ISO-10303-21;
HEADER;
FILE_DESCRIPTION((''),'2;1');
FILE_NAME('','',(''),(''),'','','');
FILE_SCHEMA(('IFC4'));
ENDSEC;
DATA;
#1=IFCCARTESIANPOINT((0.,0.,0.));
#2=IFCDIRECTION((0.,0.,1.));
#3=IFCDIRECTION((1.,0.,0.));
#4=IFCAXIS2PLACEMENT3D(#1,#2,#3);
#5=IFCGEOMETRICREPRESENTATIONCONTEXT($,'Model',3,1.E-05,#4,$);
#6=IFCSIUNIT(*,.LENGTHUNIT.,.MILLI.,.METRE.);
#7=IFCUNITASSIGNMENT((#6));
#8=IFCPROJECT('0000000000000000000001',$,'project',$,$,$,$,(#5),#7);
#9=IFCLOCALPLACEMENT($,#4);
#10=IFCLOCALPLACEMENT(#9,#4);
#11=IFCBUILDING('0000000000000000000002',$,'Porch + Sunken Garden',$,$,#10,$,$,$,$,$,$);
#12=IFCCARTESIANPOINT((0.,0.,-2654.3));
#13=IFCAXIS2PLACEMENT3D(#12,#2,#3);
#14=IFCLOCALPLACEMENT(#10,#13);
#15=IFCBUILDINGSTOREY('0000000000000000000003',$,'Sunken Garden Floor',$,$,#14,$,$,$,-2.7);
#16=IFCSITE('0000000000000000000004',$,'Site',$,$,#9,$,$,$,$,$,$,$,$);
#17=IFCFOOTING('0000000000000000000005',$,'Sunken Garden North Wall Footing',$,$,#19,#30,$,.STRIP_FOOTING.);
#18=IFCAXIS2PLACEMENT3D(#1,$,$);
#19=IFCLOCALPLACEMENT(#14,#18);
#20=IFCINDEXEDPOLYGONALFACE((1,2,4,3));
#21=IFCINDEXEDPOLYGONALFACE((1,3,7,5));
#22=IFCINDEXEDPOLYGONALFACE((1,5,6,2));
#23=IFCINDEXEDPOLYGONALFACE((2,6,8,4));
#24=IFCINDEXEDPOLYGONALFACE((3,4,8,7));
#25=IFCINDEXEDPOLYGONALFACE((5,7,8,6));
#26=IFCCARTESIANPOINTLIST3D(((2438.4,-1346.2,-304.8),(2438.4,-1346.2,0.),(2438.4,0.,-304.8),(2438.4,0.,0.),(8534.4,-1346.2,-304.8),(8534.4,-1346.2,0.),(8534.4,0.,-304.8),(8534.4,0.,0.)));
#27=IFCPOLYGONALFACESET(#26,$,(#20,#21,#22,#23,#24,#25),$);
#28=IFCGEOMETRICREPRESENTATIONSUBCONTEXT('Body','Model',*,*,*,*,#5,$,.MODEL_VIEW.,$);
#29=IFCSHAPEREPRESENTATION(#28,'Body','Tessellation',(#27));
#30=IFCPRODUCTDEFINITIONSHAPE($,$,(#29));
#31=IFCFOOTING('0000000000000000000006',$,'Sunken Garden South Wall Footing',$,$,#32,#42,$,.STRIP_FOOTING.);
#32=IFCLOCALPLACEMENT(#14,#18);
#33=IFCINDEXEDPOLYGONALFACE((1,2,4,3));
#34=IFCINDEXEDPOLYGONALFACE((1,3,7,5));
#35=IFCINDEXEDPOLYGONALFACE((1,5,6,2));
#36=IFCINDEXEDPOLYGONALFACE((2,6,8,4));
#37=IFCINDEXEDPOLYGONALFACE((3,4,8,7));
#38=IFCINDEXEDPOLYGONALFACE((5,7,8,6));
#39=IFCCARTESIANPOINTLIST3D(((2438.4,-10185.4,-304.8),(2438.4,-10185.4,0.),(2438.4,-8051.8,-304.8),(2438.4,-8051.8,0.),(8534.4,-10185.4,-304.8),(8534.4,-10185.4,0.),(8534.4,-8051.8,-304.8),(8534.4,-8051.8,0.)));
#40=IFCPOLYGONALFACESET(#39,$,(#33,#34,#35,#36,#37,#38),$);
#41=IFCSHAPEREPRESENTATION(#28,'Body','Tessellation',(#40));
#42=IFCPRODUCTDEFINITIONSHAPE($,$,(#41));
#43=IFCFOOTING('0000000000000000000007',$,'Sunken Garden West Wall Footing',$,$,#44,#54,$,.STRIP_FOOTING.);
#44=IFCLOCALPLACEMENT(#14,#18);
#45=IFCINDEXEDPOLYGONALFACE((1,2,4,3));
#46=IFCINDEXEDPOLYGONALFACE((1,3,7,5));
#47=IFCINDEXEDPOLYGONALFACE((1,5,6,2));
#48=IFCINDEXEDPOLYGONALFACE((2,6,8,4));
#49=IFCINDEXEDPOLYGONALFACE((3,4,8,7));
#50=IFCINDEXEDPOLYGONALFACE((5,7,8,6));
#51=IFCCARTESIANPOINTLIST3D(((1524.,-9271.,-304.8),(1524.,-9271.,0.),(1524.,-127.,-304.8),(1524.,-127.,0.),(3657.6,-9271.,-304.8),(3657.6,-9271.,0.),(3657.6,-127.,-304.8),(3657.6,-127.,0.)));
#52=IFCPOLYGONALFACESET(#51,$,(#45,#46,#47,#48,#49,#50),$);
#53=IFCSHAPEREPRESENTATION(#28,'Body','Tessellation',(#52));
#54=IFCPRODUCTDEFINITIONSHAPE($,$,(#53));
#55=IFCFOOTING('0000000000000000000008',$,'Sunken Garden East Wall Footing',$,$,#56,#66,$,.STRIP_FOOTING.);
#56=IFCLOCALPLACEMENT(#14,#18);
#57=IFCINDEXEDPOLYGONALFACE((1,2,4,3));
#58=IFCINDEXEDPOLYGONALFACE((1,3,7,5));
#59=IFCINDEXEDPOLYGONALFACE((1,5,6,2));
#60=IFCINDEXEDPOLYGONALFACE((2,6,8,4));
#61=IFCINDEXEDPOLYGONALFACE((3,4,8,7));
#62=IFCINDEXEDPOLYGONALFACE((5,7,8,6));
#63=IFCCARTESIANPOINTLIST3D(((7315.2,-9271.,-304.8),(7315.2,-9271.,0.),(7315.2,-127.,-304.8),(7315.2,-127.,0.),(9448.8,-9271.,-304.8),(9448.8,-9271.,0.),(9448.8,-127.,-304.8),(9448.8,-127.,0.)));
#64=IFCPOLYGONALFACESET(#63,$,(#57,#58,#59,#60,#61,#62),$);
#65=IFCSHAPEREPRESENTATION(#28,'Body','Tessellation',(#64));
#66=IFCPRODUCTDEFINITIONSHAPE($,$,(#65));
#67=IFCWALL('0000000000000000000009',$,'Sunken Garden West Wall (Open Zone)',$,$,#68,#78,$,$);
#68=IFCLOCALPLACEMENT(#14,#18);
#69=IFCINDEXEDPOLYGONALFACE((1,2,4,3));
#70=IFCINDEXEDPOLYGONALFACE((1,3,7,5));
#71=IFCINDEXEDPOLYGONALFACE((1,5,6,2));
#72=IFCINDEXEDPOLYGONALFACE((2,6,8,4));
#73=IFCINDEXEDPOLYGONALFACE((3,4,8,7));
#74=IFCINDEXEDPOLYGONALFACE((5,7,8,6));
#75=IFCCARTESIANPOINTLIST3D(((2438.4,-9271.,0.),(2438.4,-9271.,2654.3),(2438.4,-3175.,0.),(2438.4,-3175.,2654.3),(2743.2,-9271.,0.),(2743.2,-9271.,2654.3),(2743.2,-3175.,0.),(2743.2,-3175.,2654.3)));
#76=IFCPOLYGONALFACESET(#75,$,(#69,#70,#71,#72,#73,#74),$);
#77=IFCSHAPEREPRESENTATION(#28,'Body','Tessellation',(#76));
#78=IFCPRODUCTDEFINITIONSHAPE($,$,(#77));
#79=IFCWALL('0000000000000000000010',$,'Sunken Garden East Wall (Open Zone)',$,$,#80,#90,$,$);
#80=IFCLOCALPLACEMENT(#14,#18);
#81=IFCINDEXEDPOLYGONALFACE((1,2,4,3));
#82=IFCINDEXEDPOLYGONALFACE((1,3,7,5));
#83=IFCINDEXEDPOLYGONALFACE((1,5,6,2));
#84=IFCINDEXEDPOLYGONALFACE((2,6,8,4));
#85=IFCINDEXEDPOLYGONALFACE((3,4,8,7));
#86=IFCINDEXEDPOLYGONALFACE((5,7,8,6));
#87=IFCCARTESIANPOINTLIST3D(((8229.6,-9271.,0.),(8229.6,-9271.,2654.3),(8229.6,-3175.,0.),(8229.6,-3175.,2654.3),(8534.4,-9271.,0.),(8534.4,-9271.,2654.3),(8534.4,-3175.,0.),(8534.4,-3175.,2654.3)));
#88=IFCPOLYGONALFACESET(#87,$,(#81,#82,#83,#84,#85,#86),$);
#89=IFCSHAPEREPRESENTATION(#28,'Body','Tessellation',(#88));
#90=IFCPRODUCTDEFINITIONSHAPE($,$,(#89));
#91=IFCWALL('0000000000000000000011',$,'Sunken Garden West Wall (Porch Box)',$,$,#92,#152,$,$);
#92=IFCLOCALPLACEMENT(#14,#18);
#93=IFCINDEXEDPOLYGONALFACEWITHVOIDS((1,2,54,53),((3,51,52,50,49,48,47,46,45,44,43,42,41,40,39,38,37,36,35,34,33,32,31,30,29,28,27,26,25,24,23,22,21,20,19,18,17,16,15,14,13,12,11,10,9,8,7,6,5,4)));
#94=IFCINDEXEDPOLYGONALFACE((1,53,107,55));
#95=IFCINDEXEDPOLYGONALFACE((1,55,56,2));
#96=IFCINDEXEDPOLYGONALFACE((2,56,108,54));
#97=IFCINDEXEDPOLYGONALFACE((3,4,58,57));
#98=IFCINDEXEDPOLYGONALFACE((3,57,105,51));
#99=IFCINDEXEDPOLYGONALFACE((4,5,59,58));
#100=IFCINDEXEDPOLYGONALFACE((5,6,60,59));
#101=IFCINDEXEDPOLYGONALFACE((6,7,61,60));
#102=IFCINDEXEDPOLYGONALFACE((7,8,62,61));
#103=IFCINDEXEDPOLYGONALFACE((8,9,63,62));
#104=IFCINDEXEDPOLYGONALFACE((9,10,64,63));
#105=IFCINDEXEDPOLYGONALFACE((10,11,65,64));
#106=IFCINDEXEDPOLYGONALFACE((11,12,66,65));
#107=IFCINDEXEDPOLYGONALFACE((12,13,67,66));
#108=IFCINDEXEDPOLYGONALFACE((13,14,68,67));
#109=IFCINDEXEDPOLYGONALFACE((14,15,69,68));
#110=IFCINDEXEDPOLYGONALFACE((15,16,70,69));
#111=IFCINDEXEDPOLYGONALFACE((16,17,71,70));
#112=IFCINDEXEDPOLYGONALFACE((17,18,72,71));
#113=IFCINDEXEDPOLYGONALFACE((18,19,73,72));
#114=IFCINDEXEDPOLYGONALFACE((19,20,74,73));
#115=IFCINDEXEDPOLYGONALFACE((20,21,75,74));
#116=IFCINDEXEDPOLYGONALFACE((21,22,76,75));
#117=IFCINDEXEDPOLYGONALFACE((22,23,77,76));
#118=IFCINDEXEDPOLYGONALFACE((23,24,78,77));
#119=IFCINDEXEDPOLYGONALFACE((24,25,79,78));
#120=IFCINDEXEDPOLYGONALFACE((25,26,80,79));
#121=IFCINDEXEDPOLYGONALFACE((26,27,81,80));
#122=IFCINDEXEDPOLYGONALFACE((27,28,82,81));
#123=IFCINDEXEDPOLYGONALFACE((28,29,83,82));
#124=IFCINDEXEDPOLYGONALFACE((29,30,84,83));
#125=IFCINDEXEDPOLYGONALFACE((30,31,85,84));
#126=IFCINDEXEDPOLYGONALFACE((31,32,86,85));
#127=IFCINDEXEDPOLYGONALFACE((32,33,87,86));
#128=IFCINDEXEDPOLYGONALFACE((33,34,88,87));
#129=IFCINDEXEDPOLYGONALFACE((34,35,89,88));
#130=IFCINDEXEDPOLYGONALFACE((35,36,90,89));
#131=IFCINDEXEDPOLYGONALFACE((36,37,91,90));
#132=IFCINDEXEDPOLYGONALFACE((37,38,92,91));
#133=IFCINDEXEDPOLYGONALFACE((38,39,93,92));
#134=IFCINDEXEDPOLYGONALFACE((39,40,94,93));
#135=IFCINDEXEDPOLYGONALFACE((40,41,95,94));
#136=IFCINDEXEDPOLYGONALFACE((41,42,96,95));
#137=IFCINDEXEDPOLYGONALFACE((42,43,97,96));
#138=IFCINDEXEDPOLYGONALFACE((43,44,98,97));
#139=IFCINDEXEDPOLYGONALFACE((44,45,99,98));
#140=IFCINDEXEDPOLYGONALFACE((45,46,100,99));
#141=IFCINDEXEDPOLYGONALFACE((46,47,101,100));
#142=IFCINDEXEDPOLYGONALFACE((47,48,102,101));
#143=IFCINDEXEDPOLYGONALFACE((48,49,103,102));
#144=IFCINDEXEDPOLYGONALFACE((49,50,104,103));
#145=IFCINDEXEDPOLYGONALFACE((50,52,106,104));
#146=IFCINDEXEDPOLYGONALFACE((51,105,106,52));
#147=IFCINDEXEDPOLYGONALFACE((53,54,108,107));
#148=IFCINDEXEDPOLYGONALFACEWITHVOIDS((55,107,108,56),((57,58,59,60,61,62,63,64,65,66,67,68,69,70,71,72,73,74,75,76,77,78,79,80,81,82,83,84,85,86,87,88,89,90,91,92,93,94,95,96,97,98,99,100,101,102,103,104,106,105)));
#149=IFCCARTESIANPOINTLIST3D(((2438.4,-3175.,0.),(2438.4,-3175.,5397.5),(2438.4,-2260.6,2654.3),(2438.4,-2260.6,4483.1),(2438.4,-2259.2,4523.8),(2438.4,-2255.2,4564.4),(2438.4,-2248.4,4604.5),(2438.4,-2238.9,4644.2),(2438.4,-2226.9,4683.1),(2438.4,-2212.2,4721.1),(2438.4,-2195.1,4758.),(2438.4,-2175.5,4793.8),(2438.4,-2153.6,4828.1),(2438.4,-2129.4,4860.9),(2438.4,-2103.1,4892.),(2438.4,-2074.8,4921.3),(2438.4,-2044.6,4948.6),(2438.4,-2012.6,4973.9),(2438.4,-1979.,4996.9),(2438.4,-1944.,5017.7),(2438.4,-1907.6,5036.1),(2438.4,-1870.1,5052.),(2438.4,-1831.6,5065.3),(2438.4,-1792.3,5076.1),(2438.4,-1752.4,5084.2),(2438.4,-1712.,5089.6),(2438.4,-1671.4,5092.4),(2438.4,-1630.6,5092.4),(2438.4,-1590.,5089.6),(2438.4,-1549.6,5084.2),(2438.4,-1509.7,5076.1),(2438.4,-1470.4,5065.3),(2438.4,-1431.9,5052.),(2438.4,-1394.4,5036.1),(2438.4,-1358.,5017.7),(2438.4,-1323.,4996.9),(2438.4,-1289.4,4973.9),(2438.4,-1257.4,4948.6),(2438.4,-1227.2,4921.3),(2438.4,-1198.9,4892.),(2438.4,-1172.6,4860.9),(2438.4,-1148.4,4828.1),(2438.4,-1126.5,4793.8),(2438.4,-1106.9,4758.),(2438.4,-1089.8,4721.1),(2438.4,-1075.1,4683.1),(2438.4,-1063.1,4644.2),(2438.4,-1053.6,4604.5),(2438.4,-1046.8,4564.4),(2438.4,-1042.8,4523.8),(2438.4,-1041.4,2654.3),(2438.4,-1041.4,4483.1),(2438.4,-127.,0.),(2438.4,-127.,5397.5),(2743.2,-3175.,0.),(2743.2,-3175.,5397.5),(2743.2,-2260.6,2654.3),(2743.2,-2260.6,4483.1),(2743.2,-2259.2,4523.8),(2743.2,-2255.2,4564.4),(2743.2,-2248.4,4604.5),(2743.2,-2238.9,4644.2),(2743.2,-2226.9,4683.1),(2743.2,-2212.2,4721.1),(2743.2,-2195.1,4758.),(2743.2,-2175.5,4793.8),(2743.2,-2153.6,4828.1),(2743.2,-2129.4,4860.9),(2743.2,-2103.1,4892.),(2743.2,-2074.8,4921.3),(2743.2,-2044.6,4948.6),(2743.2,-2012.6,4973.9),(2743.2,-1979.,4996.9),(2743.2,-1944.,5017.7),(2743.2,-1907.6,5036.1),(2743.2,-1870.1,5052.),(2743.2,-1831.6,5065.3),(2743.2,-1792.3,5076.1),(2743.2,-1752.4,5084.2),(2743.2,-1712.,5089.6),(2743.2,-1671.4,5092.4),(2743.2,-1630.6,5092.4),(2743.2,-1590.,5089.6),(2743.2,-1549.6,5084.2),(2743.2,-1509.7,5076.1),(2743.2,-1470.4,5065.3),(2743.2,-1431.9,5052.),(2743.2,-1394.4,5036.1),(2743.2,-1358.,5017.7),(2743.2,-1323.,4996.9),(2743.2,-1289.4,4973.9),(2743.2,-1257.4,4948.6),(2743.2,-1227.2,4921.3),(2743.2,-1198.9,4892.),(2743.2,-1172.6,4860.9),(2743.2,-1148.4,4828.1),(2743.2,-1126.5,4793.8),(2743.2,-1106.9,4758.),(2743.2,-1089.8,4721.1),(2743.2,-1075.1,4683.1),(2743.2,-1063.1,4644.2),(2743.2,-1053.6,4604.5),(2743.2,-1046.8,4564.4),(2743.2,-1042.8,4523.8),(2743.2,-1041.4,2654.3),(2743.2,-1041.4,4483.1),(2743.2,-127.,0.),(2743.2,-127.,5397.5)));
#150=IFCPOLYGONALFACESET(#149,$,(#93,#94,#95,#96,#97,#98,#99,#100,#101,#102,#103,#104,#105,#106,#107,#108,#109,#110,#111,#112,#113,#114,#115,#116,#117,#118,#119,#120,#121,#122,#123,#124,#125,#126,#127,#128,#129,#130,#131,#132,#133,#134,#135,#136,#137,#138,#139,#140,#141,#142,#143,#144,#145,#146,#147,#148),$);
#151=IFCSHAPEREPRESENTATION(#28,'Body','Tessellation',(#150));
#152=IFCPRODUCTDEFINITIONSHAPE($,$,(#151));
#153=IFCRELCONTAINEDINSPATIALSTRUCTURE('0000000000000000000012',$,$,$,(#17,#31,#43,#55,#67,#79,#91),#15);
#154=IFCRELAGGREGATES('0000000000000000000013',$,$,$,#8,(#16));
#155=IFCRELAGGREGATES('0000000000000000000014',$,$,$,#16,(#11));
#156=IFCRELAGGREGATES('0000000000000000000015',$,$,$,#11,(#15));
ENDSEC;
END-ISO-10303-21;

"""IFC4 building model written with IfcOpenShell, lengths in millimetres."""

from ifc_helpers import new_model, si_unit, frame, origin_with_axes, place, context, subcontext, project, spatial, indexed_curve, outline, extrude, element, save


model = new_model("IFC4")

# Units and contexts
model_context = context("Model", 3, precision=1e-05, world=origin_with_axes())
body_context = subcontext(model_context, "Body", "Model", "MODEL_VIEW")
ifc_project = project(units=[si_unit("LENGTHUNIT", "METRE", prefix="MILLI")], contexts=[model_context])

# Site, building, storey
site_placement = place(None, origin_with_axes())
site = spatial("IfcSite", under=ifc_project, at=site_placement, Name="Site")
building_placement = place(site_placement, origin_with_axes())
building = spatial("IfcBuilding", under=site, at=building_placement, Name="Porch + Sunken Garden")
storey_placement = place(building_placement, frame((0.0, 0.0, -2654.3), z_axis=(0.0, 0.0, 1.0), x_axis=(1.0, 0.0, 0.0)))
storey = spatial("IfcBuildingStorey", under=building, at=storey_placement, Name="Sunken Garden Floor", Elevation=-2.7)

# Footings
footing_1_placement = place(storey_placement, frame((2438.4, -1346.2, -304.8), z_axis=(0.0, 0.0, 1.0), x_axis=(1.0, 0.0, 0.0)))
element("IfcFooting", 1, at=footing_1_placement, inside=storey, Name="Sunken Garden North Wall Footing", PredefinedType="STRIP_FOOTING", context=body_context, shape_type="SweptSolid", body=[
    extrude(outline(indexed_curve([(0.0, 0.0), (6096.0, 0.0), (6096.0, 1346.2), (0.0, 1346.2), (0.0, 0.0)])), origin_with_axes(), (0.0, 0.0, 1.0), 304.8),
])
footing_2_placement = place(storey_placement, frame((2438.4, -10185.4, -304.8), z_axis=(0.0, 0.0, 1.0), x_axis=(1.0, 0.0, 0.0)))
element("IfcFooting", 2, at=footing_2_placement, inside=storey, Name="Sunken Garden South Wall Footing", PredefinedType="STRIP_FOOTING", context=body_context, shape_type="SweptSolid", body=[
    extrude(outline(indexed_curve([(0.0, 0.0), (6096.0, 0.0), (6096.0, 2133.6), (0.0, 2133.6), (0.0, 0.0)])), origin_with_axes(), (0.0, 0.0, 1.0), 304.8),
])
for number, where, z_axis, x_axis, name in (
    (3, (1524.0, -9271.0, -304.8), (0.0, 0.0, 1.0), (1.0, 0.0, 0.0), "Sunken Garden West Wall Footing"),
    (4, (7315.2, -9271.0, -304.8), (0.0, 0.0, 1.0), (1.0, 0.0, 0.0), "Sunken Garden East Wall Footing"),
):
    element("IfcFooting", number, at=place(storey_placement, frame(where, z_axis=z_axis, x_axis=x_axis)), inside=storey, Name=name, PredefinedType="STRIP_FOOTING", context=body_context, shape_type="SweptSolid", body=[
        extrude(outline(indexed_curve([(0.0, 0.0), (2133.6, 0.0), (2133.6, 9144.0), (0.0, 9144.0), (0.0, 0.0)])), origin_with_axes(), (0.0, 0.0, 1.0), 304.8),
    ])

# Walls
for number, where, z_axis, x_axis, name in (
    (5, (2438.4, -9271.0, 0.0), (0.0, 0.0, 1.0), (1.0, 0.0, 0.0), "Sunken Garden West Wall (Open Zone)"),
    (6, (8229.6, -9271.0, 0.0), (0.0, 0.0, 1.0), (1.0, 0.0, 0.0), "Sunken Garden East Wall (Open Zone)"),
):
    element("IfcWall", number, at=place(storey_placement, frame(where, z_axis=z_axis, x_axis=x_axis)), inside=storey, Name=name, context=body_context, shape_type="SweptSolid", body=[
        extrude(outline(indexed_curve([(0.0, 0.0), (304.8, 0.0), (304.8, 6096.0), (0.0, 6096.0), (0.0, 0.0)])), origin_with_axes(), (0.0, 0.0, 1.0), 2654.3),
    ])
wall_1_placement = place(storey_placement, frame((2438.4, -127.0, 0.0), z_axis=(1.0, 0.0, 0.0), x_axis=(0.0, -1.0, 0.0)))
element("IfcWall", 7, at=wall_1_placement, inside=storey, Name="Sunken Garden West Wall (Porch Box)", context=body_context, shape_type="SweptSolid", body=[
    extrude(outline(indexed_curve([(0.0, 0.0), (3048.0, 0.0), (3048.0, -5397.5), (0.0, -5397.5), (0.0, 0.0)]), holes=[indexed_curve([(914.4, -2654.3), (914.4, -4483.1), (914.4, -4483.1), (915.8, -4523.8), (919.8, -4564.4), (926.6, -4604.5), (936.1, -4644.2), (948.1, -4683.1), (962.8, -4721.1), (979.9, -4758.0), (999.5, -4793.8), (1021.4, -4828.1), (1045.6, -4860.9), (1071.9, -4892.0), (1100.2, -4921.3), (1130.4, -4948.6), (1162.4, -4973.9), (1196.0, -4996.9), (1231.0, -5017.7), (1267.4, -5036.1), (1304.9, -5052.0), (1343.4, -5065.3), (1382.7, -5076.1), (1422.6, -5084.2), (1463.0, -5089.6), (1503.6, -5092.4), (1544.4, -5092.4), (1585.0, -5089.6), (1625.4, -5084.2), (1665.3, -5076.1), (1704.6, -5065.3), (1743.1, -5052.0), (1780.6, -5036.1), (1817.0, -5017.7), (1852.0, -4996.9), (1885.6, -4973.9), (1917.6, -4948.6), (1947.8, -4921.3), (1976.1, -4892.0), (2002.4, -4860.9), (2026.6, -4828.1), (2048.5, -4793.8), (2068.1, -4758.0), (2085.2, -4721.1), (2099.9, -4683.1), (2111.9, -4644.2), (2121.4, -4604.5), (2128.2, -4564.4), (2132.2, -4523.8), (2133.6, -4483.1), (2133.6, -2654.3), (914.4, -2654.3)])]), origin_with_axes(), (0.0, 0.0, 1.0), 304.8),
])

save(model, "model.ifc")
